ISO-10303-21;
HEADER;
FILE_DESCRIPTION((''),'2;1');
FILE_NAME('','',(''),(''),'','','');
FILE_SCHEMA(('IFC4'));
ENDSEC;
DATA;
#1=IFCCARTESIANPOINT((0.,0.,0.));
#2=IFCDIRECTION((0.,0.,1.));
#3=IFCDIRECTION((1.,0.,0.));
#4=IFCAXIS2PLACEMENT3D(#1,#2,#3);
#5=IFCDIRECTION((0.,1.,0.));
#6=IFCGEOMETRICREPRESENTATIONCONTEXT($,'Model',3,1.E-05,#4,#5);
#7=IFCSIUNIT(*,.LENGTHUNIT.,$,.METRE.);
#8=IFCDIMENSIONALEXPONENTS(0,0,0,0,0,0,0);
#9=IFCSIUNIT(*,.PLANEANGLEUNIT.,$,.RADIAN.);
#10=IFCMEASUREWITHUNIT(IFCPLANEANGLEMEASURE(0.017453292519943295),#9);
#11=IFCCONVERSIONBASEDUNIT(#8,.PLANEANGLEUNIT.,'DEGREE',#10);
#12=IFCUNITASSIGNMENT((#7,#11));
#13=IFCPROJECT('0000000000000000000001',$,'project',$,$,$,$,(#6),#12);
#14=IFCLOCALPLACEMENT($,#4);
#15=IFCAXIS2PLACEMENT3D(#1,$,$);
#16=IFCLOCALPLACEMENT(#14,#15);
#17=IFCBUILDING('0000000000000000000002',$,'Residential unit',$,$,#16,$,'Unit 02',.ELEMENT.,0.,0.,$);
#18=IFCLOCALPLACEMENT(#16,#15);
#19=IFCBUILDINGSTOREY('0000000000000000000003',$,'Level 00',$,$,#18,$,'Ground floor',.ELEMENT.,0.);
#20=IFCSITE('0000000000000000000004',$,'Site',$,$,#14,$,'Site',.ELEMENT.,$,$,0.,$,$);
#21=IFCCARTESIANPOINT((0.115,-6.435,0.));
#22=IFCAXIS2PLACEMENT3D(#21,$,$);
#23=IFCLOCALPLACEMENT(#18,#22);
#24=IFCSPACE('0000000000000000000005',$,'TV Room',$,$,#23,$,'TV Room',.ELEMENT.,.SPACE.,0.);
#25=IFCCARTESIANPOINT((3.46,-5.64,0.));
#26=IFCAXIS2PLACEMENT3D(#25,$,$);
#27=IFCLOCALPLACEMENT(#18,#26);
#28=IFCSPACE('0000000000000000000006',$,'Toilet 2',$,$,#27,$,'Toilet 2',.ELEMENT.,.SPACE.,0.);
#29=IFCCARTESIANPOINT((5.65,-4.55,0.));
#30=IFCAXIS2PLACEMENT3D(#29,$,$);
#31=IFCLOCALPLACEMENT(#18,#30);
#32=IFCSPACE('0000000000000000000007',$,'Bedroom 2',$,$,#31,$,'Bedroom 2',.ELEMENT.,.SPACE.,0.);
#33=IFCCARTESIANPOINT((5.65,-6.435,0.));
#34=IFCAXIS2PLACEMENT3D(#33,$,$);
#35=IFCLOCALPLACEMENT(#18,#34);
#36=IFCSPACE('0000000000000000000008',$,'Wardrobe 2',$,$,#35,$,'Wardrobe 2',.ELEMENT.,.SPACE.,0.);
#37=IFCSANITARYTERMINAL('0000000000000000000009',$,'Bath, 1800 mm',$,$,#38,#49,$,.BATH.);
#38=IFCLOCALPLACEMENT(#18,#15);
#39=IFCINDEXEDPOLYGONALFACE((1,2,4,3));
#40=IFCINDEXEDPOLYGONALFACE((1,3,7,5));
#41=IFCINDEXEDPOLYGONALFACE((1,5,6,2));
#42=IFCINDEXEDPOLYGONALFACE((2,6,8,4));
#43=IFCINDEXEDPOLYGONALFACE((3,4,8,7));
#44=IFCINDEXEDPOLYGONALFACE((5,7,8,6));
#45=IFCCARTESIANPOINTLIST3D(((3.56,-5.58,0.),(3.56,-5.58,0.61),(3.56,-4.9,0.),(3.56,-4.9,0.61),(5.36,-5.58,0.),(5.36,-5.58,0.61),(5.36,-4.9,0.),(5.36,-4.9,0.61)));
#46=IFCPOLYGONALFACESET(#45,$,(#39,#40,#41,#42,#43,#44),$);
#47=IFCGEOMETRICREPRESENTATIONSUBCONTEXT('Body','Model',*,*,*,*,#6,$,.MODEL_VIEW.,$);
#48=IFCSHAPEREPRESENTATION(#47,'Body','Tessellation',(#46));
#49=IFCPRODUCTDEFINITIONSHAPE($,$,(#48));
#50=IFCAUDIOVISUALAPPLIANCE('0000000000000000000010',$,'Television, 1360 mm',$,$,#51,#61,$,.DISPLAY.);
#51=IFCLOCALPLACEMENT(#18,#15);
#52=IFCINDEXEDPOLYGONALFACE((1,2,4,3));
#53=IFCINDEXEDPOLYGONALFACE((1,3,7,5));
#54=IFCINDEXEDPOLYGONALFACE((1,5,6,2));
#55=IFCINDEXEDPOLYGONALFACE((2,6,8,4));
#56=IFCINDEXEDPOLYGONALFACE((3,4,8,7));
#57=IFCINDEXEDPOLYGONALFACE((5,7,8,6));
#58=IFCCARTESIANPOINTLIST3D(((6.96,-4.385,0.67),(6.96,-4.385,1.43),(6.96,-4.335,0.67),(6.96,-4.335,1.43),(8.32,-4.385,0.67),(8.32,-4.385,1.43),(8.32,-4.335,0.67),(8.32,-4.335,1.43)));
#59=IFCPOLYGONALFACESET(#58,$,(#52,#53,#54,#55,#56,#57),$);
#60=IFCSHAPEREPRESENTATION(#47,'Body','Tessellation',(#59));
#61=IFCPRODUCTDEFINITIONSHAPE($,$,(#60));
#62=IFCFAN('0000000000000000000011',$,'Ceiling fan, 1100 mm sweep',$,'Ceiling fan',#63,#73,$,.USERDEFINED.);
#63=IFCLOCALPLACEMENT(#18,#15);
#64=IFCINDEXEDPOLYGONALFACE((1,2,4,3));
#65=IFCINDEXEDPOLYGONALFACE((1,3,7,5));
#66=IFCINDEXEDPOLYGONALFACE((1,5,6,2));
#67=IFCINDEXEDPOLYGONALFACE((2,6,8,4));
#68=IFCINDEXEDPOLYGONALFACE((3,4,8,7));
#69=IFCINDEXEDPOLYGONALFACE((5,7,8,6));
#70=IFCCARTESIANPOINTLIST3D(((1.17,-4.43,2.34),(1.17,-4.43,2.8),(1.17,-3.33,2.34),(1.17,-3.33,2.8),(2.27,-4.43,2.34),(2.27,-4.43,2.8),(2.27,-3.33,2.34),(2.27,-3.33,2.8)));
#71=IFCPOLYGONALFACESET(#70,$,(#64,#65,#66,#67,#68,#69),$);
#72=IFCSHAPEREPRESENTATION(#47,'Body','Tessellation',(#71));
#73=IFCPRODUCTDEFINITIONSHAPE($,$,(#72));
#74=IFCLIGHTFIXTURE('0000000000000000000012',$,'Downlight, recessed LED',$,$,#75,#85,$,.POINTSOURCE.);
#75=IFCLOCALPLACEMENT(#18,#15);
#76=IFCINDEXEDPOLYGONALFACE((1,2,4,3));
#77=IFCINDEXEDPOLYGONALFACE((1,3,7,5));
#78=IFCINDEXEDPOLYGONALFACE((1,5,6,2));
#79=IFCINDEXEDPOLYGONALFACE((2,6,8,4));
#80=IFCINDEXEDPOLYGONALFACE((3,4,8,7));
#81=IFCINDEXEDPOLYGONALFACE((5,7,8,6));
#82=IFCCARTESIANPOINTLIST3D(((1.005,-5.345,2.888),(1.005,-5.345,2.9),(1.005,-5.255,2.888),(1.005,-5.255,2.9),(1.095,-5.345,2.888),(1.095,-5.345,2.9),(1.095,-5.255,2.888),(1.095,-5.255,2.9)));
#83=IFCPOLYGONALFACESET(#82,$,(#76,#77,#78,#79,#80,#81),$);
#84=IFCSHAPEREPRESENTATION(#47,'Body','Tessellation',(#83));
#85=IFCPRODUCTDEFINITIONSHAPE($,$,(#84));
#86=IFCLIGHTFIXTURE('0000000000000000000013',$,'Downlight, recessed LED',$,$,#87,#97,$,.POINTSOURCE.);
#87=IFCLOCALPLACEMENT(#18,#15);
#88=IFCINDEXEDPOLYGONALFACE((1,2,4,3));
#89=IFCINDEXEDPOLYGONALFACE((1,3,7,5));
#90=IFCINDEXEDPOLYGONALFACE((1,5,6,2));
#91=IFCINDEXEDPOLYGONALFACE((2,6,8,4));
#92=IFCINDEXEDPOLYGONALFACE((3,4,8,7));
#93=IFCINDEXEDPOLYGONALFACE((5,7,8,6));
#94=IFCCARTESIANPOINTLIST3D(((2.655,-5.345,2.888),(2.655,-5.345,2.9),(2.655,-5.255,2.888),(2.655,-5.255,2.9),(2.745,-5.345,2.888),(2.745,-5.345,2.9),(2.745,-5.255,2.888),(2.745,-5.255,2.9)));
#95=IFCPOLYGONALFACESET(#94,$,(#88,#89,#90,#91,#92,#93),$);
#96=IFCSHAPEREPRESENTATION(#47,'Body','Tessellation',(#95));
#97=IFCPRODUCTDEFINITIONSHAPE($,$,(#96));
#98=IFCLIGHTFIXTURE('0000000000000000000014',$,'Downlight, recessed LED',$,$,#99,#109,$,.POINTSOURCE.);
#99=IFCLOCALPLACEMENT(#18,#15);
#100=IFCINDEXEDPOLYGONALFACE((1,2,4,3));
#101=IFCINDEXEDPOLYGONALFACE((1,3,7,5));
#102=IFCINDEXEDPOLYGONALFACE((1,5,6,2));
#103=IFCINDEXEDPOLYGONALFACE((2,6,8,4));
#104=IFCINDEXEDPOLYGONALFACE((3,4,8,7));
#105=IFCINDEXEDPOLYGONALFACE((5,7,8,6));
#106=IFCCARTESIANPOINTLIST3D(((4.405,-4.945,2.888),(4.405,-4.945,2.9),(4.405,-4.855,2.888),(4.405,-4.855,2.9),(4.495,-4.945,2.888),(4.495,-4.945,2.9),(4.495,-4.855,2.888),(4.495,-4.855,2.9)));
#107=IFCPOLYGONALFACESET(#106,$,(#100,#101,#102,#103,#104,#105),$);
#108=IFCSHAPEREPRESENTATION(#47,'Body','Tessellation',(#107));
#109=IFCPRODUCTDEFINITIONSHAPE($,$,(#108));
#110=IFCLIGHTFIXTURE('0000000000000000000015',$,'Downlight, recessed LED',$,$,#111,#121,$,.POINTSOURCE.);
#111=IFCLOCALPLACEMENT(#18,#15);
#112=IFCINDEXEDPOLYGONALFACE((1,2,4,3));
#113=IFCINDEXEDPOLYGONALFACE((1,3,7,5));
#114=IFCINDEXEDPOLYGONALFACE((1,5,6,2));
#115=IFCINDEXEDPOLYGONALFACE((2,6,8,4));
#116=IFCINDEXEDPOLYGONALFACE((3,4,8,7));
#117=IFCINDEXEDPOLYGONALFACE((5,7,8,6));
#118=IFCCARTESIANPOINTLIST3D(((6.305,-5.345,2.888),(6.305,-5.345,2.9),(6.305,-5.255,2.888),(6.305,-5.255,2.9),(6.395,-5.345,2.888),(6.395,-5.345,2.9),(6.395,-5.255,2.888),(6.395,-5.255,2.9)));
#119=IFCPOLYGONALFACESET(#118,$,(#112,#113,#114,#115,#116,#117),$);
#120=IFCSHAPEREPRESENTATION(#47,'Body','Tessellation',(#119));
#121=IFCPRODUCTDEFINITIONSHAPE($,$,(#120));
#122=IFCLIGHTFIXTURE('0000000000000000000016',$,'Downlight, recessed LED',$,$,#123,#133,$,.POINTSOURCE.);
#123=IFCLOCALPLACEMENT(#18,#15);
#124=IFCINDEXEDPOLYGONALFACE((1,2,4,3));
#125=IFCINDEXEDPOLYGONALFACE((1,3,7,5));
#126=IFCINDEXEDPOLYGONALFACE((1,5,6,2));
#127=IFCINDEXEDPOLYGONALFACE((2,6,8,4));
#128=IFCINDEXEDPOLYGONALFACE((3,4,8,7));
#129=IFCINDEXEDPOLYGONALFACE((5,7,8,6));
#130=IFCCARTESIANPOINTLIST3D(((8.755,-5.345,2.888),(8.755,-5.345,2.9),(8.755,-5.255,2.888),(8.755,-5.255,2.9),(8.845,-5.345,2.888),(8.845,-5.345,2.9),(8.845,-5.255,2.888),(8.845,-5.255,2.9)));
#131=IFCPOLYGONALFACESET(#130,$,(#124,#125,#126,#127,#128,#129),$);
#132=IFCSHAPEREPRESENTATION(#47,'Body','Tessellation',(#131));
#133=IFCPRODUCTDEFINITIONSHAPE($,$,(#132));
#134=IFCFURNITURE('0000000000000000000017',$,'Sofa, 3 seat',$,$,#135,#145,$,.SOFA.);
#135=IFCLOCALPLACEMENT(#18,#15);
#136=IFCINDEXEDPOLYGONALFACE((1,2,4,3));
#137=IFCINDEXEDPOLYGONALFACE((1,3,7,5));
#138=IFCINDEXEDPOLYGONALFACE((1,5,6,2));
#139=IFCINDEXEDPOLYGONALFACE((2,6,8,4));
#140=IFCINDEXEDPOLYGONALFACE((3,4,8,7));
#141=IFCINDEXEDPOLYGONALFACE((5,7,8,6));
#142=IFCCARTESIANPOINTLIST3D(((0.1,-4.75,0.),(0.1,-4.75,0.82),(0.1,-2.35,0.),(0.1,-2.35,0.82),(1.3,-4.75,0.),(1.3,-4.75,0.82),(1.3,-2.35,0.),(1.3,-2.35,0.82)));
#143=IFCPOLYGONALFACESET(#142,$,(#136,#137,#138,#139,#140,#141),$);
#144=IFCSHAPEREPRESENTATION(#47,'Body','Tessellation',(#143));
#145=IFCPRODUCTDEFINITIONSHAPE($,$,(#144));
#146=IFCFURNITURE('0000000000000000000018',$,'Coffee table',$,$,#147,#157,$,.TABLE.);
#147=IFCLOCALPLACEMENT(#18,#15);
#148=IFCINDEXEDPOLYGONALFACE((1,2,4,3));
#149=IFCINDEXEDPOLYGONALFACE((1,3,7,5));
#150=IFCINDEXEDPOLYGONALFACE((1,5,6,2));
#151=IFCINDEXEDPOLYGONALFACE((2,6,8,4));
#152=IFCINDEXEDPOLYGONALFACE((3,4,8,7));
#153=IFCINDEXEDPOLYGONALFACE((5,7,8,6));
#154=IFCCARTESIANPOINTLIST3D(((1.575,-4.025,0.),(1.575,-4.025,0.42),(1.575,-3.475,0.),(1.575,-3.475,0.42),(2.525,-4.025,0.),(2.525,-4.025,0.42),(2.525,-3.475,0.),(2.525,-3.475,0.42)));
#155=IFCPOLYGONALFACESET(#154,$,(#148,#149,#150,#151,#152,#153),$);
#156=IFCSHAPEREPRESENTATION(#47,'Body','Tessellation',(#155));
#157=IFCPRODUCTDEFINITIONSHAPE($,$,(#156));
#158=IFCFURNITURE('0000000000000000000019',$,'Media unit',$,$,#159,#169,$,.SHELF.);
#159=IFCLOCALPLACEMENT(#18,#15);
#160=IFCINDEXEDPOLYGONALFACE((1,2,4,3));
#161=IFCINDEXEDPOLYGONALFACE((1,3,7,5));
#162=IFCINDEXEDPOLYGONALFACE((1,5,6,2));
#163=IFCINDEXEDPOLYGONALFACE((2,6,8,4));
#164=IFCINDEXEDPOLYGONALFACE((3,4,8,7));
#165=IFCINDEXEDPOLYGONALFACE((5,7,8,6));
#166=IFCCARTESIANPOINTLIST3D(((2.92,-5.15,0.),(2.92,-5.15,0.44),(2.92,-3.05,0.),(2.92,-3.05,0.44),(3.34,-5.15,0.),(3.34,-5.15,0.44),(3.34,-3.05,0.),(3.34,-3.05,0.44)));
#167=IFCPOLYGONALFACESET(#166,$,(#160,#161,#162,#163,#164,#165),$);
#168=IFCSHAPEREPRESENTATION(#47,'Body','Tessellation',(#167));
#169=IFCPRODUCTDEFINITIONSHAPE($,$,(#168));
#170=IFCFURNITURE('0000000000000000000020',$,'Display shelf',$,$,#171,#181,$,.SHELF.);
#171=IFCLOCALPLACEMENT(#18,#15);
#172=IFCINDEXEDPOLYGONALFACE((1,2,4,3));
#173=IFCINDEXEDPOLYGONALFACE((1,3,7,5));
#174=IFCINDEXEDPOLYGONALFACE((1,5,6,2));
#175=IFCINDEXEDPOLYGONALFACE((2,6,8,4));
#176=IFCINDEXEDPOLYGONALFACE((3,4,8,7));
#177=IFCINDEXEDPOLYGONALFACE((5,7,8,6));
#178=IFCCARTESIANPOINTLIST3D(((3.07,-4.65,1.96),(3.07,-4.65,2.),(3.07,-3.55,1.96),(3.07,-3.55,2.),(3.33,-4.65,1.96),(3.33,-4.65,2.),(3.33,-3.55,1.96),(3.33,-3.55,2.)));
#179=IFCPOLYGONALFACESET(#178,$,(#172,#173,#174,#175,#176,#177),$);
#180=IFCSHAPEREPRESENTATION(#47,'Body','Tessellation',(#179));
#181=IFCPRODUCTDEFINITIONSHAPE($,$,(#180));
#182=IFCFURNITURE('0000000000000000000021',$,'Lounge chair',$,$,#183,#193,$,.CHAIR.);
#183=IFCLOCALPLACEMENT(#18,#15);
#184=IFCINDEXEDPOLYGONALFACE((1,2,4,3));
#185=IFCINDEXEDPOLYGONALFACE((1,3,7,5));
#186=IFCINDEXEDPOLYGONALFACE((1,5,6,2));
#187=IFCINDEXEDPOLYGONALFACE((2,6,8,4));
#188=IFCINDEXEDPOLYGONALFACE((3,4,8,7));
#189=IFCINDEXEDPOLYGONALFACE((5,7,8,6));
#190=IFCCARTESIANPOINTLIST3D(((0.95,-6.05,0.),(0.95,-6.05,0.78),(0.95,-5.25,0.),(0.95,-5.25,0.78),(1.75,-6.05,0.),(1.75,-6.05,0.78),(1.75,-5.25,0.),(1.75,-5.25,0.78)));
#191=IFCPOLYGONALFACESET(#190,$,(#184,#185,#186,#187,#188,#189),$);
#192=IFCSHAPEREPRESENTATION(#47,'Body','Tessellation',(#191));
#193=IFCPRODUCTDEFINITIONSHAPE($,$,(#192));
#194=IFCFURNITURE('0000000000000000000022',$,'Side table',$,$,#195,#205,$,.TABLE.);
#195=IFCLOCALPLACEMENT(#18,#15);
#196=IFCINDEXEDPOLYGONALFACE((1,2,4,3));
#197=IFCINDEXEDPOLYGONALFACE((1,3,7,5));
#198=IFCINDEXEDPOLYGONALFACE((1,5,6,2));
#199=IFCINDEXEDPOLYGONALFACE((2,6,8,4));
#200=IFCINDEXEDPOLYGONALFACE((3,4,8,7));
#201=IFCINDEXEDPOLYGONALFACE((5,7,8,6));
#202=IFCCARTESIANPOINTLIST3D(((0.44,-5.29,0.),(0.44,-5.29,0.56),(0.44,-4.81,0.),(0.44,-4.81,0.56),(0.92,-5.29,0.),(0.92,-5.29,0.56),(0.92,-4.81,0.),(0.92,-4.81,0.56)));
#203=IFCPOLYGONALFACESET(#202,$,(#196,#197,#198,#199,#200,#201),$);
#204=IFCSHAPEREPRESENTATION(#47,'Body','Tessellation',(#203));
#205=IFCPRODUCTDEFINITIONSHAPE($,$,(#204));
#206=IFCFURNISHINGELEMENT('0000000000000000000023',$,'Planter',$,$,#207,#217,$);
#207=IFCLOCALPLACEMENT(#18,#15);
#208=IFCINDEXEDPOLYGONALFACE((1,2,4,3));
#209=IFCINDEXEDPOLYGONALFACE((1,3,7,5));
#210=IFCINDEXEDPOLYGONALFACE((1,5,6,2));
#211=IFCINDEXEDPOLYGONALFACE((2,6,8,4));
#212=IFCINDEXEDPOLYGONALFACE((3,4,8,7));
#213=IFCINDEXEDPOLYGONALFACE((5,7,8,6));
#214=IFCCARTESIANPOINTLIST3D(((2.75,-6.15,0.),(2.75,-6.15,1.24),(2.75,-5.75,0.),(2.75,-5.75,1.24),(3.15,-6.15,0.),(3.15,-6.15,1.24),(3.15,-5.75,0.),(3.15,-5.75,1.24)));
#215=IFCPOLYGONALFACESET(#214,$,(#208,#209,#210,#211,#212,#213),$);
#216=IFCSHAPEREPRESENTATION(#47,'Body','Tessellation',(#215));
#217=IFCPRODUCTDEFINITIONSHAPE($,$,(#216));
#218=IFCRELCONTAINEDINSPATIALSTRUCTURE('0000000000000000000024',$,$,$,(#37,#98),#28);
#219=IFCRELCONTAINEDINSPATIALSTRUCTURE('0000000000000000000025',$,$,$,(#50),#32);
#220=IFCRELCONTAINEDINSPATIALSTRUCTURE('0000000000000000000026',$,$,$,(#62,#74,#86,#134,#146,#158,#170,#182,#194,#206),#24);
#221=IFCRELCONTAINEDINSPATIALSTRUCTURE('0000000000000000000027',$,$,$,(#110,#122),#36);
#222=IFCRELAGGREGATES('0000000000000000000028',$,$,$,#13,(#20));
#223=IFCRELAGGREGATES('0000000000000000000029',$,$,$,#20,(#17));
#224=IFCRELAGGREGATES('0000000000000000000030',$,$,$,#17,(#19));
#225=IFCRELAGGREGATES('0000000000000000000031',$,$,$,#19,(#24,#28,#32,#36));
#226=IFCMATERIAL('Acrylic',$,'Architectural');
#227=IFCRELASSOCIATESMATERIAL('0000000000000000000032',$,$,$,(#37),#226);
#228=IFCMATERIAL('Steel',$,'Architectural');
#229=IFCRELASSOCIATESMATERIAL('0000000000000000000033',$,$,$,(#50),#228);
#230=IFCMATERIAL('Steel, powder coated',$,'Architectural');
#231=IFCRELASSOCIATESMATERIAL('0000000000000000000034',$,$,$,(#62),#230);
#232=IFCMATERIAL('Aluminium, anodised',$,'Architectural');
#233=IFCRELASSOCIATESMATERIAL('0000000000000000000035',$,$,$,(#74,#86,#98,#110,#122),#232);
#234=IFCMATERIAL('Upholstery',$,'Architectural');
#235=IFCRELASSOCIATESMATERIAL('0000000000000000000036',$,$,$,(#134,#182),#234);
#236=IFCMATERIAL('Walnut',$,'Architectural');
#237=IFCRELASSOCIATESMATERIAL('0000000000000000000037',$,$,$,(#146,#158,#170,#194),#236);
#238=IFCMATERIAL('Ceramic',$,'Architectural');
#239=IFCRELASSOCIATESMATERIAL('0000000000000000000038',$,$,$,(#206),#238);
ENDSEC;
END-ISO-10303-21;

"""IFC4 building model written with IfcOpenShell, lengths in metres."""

from ifc_helpers import new_model, entity, si_unit, converted_unit, direction, frame, frame_2d, origin, origin_with_axes, place, context, subcontext, project, spatial, rectangle, extrude, material, element, save


model = new_model("IFC4")

# Units and contexts
model_context = context("Model", 3, precision=1e-05, world=origin_with_axes(), true_north=direction((0.0, 1.0, 0.0)))
body_context = subcontext(model_context, "Body", "Model", "MODEL_VIEW")
ifc_project = project(units=[si_unit("LENGTHUNIT", "METRE"), converted_unit("PLANEANGLEUNIT", "DEGREE", entity("IfcPlaneAngleMeasure", 0.017453292519943295), si_unit("PLANEANGLEUNIT", "RADIAN"), dimensions=[0, 0, 0, 0, 0, 0, 0])], contexts=[model_context])

# Site, building, storey
site_placement = place(None, origin_with_axes())
site = spatial("IfcSite", under=ifc_project, at=site_placement, Name="Site", LongName="Site", CompositionType="ELEMENT", RefElevation=0.0)
building_placement = place(site_placement, origin())
building = spatial("IfcBuilding", under=site, at=building_placement, Name="Residential unit", LongName="Unit 02", CompositionType="ELEMENT", ElevationOfRefHeight=0.0, ElevationOfTerrain=0.0)
storey_placement = place(building_placement, origin())
storey = spatial("IfcBuildingStorey", under=building, at=storey_placement, Name="Level 00", LongName="Ground floor", CompositionType="ELEMENT", Elevation=0.0)

# Shared definitions
space_1_placement = place(storey_placement, frame((0.115, -6.435, 0.0)))
space_1 = spatial("IfcSpace", under=storey, at=space_1_placement, Name="TV Room", LongName="TV Room", CompositionType="ELEMENT", PredefinedType="SPACE", ElevationWithFlooring=0.0)

# Shared definitions
space_2_placement = place(storey_placement, frame((3.46, -5.64, 0.0)))
space_2 = spatial("IfcSpace", under=storey, at=space_2_placement, Name="Toilet 2", LongName="Toilet 2", CompositionType="ELEMENT", PredefinedType="SPACE", ElevationWithFlooring=0.0)

# Shared definitions
space_3_placement = place(storey_placement, frame((5.65, -4.55, 0.0)))
space_3 = spatial("IfcSpace", under=storey, at=space_3_placement, Name="Bedroom 2", LongName="Bedroom 2", CompositionType="ELEMENT", PredefinedType="SPACE", ElevationWithFlooring=0.0)

# Shared definitions
space_4_placement = place(storey_placement, frame((5.65, -6.435, 0.0)))
space_4 = spatial("IfcSpace", under=storey, at=space_4_placement, Name="Wardrobe 2", LongName="Wardrobe 2", CompositionType="ELEMENT", PredefinedType="SPACE", ElevationWithFlooring=0.0)

# Shared definitions
ifc_material_1 = material(Name="Steel", Category="Architectural")

# Sanitary terminal
ifc_material_2 = material(Name="Acrylic", Category="Architectural")
sanitary_terminal_1_placement = place(storey_placement, frame((3.56, -5.58, 0.0)))
element("IfcSanitaryTerminal", 1, at=sanitary_terminal_1_placement, inside=space_2, material=ifc_material_2, Name="Bath, 1800 mm", PredefinedType="BATH", context=body_context, shape_type="SweptSolid", body=[
    extrude(rectangle(XDim=1.8, YDim=0.68, at=frame_2d((0.9, 0.34))), origin(), (0.0, 0.0, 1.0), 0.61),
])

# Audio visual appliance
audio_visual_appliance_1_placement = place(storey_placement, frame((6.96, -4.385, 0.67)))
element("IfcAudioVisualAppliance", 2, at=audio_visual_appliance_1_placement, inside=space_3, material=ifc_material_1, Name="Television, 1360 mm", PredefinedType="DISPLAY", context=body_context, shape_type="SweptSolid", body=[
    extrude(rectangle(XDim=1.36, YDim=0.05, at=frame_2d((0.68, 0.025))), origin(), (0.0, 0.0, 1.0), 0.76),
])

# Fan
ifc_material_3 = material(Name="Steel, powder coated", Category="Architectural")
fan_placement = place(storey_placement, frame((1.17, -4.43, 2.34)))
element("IfcFan", 3, at=fan_placement, inside=space_1, material=ifc_material_3, Name="Ceiling fan, 1100 mm sweep", ObjectType="Ceiling fan", PredefinedType="USERDEFINED", context=body_context, shape_type="SweptSolid", body=[
    extrude(rectangle(XDim=1.1, YDim=1.1, at=frame_2d((0.55, 0.55))), origin(), (0.0, 0.0, 1.0), 0.46),
])

# Light fixtures
ifc_material_4 = material(Name="Aluminium, anodised", Category="Architectural")
for number, where, name in (
    (4, (1.005, -5.345, 2.888), "Downlight, recessed LED"),
    (5, (2.655, -5.345, 2.888), "Downlight, recessed LED"),
):
    element("IfcLightFixture", number, at=place(storey_placement, frame(where)), inside=space_1, material=ifc_material_4, Name=name, PredefinedType="POINTSOURCE", context=body_context, shape_type="SweptSolid", body=[
        extrude(rectangle(XDim=0.09, YDim=0.09, at=frame_2d((0.045, 0.045))), origin(), (0.0, 0.0, 1.0), 0.012),
    ])
light_fixture_1_placement = place(storey_placement, frame((4.405, -4.945, 2.888)))
element("IfcLightFixture", 6, at=light_fixture_1_placement, inside=space_2, material=ifc_material_4, Name="Downlight, recessed LED", PredefinedType="POINTSOURCE", context=body_context, shape_type="SweptSolid", body=[
    extrude(rectangle(XDim=0.09, YDim=0.09, at=frame_2d((0.045, 0.045))), origin(), (0.0, 0.0, 1.0), 0.012),
])
for number, where, name in (
    (7, (6.305, -5.345, 2.888), "Downlight, recessed LED"),
    (8, (8.755, -5.345, 2.888), "Downlight, recessed LED"),
):
    element("IfcLightFixture", number, at=place(storey_placement, frame(where)), inside=space_4, material=ifc_material_4, Name=name, PredefinedType="POINTSOURCE", context=body_context, shape_type="SweptSolid", body=[
        extrude(rectangle(XDim=0.09, YDim=0.09, at=frame_2d((0.045, 0.045))), origin(), (0.0, 0.0, 1.0), 0.012),
    ])

# Furniture
ifc_material_5 = material(Name="Upholstery", Category="Architectural")
furniture_1_placement = place(storey_placement, frame((0.1, -4.75, 0.0)))
element("IfcFurniture", 9, at=furniture_1_placement, inside=space_1, material=ifc_material_5, Name="Sofa, 3 seat", PredefinedType="SOFA", context=body_context, shape_type="SweptSolid", body=[
    extrude(rectangle(XDim=1.2, YDim=2.4, at=frame_2d((0.6, 1.2))), origin(), (0.0, 0.0, 1.0), 0.82),
])
ifc_material_6 = material(Name="Walnut", Category="Architectural")
furniture_2_placement = place(storey_placement, frame((1.575, -4.025, 0.0)))
element("IfcFurniture", 10, at=furniture_2_placement, inside=space_1, material=ifc_material_6, Name="Coffee table", PredefinedType="TABLE", context=body_context, shape_type="SweptSolid", body=[
    extrude(rectangle(XDim=0.95, YDim=0.55, at=frame_2d((0.475, 0.275))), origin(), (0.0, 0.0, 1.0), 0.42),
])
furniture_3_placement = place(storey_placement, frame((2.92, -5.15, 0.0)))
element("IfcFurniture", 11, at=furniture_3_placement, inside=space_1, material=ifc_material_6, Name="Media unit", PredefinedType="SHELF", context=body_context, shape_type="SweptSolid", body=[
    extrude(rectangle(XDim=0.42, YDim=2.1, at=frame_2d((0.21, 1.05))), origin(), (0.0, 0.0, 1.0), 0.44),
])
furniture_4_placement = place(storey_placement, frame((3.07, -4.65, 1.96)))
element("IfcFurniture", 12, at=furniture_4_placement, inside=space_1, material=ifc_material_6, Name="Display shelf", PredefinedType="SHELF", context=body_context, shape_type="SweptSolid", body=[
    extrude(rectangle(XDim=0.26, YDim=1.1, at=frame_2d((0.13, 0.55))), origin(), (0.0, 0.0, 1.0), 0.04),
])
furniture_5_placement = place(storey_placement, frame((0.95, -6.05, 0.0)))
element("IfcFurniture", 13, at=furniture_5_placement, inside=space_1, material=ifc_material_5, Name="Lounge chair", PredefinedType="CHAIR", context=body_context, shape_type="SweptSolid", body=[
    extrude(rectangle(XDim=0.8, YDim=0.8, at=frame_2d((0.4, 0.4))), origin(), (0.0, 0.0, 1.0), 0.78),
])
furniture_6_placement = place(storey_placement, frame((0.44, -5.29, 0.0)))
element("IfcFurniture", 14, at=furniture_6_placement, inside=space_1, material=ifc_material_6, Name="Side table", PredefinedType="TABLE", context=body_context, shape_type="SweptSolid", body=[
    extrude(rectangle(XDim=0.48, YDim=0.48, at=frame_2d((0.24, 0.24))), origin(), (0.0, 0.0, 1.0), 0.56),
])

# Furnishing element
ifc_material_7 = material(Name="Ceramic", Category="Architectural")
furnishing_1_placement = place(storey_placement, frame((2.75, -6.15, 0.0)))
element("IfcFurnishingElement", 15, at=furnishing_1_placement, inside=space_1, material=ifc_material_7, Name="Planter", context=body_context, shape_type="SweptSolid", body=[
    extrude(rectangle(XDim=0.4, YDim=0.4, at=frame_2d((0.2, 0.2))), origin(), (0.0, 0.0, 1.0), 1.24),
])

save(model, "model.ifc")
